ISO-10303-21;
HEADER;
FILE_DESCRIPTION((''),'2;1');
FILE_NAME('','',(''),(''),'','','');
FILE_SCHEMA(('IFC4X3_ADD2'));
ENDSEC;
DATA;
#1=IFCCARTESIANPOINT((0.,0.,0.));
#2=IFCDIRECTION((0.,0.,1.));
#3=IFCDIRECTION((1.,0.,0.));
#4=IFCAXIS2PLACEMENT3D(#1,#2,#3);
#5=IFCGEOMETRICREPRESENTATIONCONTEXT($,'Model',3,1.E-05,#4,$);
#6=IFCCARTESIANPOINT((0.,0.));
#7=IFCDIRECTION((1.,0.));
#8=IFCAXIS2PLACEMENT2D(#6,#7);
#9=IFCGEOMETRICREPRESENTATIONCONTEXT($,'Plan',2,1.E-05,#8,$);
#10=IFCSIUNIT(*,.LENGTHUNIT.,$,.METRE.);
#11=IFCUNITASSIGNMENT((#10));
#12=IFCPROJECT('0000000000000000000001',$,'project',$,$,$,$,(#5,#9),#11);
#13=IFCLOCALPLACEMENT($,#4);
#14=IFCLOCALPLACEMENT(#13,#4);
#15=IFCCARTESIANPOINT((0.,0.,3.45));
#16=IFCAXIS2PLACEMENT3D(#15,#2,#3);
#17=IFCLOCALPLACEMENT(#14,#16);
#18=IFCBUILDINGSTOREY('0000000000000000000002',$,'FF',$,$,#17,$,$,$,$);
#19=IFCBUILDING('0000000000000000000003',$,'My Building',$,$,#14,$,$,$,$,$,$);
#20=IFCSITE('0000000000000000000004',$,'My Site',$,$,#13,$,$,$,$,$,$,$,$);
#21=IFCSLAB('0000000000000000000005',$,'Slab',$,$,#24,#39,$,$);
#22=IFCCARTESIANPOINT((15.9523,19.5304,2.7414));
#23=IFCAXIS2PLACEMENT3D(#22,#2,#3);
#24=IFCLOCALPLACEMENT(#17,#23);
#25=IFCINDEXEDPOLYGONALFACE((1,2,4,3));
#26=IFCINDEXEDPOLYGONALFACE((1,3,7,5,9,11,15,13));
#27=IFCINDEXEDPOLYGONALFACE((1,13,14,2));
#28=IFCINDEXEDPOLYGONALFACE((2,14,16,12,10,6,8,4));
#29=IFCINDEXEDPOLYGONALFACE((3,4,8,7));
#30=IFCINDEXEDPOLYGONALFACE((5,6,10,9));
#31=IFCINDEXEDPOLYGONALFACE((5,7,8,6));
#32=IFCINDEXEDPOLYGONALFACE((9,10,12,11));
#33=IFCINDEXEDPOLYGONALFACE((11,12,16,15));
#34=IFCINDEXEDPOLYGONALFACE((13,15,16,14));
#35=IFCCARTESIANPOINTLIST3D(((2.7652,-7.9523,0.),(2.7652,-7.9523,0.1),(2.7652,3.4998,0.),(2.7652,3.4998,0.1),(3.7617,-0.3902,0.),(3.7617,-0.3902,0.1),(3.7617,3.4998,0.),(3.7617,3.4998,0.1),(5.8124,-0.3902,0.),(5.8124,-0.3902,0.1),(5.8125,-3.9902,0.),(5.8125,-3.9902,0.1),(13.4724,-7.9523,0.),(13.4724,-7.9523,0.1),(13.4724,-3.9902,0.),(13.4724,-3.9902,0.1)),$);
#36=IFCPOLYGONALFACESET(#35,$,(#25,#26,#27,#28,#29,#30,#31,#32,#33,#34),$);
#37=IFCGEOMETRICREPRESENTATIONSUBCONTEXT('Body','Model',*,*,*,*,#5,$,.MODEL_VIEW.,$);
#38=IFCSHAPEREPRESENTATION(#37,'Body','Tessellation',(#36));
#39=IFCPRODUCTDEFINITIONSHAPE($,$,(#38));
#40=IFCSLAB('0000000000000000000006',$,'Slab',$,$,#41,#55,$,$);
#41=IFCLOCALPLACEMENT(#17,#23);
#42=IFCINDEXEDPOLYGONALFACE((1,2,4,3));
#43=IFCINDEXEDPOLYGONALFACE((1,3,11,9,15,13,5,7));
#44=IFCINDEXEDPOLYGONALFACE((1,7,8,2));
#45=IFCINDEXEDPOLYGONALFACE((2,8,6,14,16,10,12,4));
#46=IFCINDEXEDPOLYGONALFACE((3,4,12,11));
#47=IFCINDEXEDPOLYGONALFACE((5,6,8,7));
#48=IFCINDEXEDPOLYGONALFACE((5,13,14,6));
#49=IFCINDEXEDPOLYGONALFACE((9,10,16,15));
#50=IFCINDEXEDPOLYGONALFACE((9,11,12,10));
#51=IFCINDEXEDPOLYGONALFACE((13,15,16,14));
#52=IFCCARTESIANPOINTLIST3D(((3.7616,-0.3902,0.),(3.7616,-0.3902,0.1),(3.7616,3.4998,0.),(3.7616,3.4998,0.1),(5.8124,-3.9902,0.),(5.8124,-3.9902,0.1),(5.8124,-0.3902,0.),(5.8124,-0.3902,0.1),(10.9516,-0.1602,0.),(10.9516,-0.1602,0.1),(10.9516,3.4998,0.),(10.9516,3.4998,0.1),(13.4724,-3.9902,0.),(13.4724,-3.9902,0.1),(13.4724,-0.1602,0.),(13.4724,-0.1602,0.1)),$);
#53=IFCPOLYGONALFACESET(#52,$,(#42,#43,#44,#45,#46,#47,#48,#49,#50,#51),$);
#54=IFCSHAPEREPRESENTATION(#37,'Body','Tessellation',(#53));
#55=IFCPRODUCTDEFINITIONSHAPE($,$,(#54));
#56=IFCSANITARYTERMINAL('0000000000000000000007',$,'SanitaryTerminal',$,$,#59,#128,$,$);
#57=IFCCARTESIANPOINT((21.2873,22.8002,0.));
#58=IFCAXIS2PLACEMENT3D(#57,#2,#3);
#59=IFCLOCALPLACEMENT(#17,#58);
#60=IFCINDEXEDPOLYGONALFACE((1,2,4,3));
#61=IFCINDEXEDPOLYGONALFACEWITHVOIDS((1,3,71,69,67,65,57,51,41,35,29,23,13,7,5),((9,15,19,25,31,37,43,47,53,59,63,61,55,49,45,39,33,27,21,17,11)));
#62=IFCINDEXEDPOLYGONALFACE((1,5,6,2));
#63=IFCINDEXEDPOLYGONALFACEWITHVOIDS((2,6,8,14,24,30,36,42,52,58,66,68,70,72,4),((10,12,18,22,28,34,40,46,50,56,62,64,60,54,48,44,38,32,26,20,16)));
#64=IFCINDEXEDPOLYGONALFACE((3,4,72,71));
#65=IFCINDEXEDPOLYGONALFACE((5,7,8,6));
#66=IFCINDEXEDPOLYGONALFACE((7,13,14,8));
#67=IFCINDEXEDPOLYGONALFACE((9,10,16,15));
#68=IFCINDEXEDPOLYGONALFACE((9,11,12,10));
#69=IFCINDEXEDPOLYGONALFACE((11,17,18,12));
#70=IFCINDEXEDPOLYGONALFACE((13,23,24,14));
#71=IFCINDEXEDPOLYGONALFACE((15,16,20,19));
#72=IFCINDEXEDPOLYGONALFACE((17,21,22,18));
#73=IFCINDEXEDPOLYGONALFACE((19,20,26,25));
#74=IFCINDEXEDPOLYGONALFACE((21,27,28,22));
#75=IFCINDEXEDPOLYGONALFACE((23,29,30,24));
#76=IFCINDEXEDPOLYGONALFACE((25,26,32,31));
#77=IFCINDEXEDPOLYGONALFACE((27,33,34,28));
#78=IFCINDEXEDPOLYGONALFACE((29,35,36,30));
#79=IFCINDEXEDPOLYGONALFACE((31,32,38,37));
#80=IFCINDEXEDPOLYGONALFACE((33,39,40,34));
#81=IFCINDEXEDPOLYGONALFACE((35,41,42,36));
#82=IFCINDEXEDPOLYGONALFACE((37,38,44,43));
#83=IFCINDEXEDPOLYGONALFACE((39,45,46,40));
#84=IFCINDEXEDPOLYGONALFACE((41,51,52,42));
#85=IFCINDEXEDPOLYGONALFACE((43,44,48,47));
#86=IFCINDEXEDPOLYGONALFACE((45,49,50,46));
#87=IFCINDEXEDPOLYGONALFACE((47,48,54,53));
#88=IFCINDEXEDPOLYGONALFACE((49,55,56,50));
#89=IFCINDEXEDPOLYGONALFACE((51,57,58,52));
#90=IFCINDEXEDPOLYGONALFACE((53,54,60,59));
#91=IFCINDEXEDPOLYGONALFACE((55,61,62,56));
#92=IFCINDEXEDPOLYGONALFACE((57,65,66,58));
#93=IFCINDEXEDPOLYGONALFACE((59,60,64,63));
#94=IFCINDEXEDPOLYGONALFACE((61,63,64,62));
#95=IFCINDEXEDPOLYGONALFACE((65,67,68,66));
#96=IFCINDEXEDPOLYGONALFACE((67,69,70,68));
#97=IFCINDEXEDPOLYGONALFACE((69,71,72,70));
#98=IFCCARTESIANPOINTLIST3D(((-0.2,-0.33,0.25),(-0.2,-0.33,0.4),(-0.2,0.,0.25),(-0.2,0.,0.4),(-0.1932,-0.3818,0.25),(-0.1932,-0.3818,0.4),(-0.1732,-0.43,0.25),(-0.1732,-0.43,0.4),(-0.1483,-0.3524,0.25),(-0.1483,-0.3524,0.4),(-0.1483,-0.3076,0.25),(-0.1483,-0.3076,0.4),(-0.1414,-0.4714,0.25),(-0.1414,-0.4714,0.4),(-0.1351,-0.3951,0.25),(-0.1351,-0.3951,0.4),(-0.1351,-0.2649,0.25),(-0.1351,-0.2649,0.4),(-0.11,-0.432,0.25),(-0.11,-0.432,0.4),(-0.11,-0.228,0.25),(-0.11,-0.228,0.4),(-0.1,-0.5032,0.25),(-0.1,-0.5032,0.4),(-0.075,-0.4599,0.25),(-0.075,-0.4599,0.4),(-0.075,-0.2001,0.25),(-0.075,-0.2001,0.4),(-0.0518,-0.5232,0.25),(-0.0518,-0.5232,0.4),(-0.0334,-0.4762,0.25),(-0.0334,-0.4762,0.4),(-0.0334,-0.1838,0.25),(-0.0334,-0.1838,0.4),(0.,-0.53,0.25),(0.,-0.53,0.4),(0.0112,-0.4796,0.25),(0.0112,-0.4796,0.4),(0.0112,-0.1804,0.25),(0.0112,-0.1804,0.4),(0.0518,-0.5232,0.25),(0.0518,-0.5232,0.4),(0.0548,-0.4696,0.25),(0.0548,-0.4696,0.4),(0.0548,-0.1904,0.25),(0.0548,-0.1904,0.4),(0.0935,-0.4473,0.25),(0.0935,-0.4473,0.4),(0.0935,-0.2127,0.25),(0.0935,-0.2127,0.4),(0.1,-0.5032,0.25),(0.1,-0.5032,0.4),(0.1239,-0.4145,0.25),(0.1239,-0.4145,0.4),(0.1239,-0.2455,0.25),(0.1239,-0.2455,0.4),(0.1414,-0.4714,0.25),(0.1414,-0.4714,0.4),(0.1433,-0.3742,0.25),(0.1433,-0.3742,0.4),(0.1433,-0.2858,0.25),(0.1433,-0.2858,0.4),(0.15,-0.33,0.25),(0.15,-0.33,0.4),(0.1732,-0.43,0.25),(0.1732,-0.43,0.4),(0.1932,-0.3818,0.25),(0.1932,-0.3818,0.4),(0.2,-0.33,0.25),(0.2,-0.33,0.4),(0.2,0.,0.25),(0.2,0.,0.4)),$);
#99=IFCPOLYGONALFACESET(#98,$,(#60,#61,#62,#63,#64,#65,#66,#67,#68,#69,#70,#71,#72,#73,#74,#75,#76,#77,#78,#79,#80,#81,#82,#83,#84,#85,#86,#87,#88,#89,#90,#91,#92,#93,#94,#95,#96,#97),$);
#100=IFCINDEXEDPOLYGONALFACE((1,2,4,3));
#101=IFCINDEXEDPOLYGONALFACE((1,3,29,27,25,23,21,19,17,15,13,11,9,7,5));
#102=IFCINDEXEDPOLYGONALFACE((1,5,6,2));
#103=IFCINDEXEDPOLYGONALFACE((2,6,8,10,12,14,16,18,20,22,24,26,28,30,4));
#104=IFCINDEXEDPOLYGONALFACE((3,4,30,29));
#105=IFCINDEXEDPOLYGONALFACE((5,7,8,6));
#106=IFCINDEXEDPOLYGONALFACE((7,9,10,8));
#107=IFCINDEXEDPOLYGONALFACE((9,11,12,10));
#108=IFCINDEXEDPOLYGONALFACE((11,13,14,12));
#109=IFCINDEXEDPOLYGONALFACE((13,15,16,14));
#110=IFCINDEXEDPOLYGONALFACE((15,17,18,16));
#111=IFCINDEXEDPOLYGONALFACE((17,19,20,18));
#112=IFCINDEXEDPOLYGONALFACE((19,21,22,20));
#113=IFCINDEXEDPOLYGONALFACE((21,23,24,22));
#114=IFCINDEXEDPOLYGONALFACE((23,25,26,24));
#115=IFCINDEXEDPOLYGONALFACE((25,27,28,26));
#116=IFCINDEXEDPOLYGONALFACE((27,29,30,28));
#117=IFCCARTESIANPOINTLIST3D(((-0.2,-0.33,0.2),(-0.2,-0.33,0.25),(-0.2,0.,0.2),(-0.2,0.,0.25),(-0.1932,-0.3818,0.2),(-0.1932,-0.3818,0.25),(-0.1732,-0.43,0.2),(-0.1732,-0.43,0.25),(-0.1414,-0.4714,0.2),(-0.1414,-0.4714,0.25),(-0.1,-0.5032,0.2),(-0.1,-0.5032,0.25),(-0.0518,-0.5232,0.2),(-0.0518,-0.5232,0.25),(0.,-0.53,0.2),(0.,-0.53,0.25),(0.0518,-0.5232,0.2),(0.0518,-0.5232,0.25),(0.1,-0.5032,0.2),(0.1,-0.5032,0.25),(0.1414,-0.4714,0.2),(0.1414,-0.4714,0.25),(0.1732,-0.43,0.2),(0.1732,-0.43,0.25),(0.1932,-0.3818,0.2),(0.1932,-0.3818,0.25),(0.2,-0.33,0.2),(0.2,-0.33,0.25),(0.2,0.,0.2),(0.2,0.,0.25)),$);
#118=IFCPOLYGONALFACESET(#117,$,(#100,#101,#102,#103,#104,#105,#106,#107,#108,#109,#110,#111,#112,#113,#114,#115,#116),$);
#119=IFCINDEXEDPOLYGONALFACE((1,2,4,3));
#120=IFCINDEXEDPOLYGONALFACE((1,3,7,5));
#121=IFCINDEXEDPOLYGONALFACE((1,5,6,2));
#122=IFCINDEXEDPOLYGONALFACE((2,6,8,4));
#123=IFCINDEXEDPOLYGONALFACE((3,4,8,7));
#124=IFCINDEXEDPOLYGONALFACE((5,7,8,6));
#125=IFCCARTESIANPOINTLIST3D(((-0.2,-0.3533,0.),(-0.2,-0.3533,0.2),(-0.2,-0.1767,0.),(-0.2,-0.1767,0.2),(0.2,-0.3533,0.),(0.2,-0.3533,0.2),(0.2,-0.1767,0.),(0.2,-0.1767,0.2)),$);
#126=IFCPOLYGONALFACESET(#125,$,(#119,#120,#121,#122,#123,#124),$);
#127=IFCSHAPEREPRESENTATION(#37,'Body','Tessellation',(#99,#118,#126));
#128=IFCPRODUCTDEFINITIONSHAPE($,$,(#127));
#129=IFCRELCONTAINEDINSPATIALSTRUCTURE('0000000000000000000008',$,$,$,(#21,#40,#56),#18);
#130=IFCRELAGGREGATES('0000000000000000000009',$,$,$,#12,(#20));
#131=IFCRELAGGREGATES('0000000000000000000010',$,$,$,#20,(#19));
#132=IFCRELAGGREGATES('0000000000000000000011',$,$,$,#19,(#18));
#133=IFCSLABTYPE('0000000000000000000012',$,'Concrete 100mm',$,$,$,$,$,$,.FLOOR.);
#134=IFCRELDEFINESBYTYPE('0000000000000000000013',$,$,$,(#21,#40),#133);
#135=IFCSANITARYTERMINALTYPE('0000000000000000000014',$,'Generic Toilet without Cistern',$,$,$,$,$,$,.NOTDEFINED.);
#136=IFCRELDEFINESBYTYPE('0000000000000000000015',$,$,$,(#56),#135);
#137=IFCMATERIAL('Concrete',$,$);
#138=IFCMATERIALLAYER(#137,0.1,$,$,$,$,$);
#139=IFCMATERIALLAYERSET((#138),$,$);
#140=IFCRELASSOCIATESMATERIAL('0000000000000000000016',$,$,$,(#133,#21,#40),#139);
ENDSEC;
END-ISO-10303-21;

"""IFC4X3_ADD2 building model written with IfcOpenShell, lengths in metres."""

from ifc_helpers import new_model, entity, si_unit, frame, frame_2d, origin_with_axes, origin_2d_with_axis, place, context, subcontext, project, spatial, line, arc, indexed_curve, circle_curve, outline, extrude, shape, source, transform, mapped, material, layer, layer_set, layer_usage, type_object, type_shapes, element, save


model = new_model("IFC4X3_ADD2")

# Units and contexts
model_context = context("Model", 3, precision=1e-05, world=origin_with_axes())
plan_context = context("Plan", 2, precision=1e-05, world=origin_2d_with_axis())
body_context_1 = subcontext(model_context, "Body", "Model", "MODEL_VIEW")
body_context_2 = subcontext(plan_context, "Body", "Plan", "PLAN_VIEW")
ifc_project = project(units=[si_unit("LENGTHUNIT", "METRE")], contexts=[model_context, plan_context])

# Site, building, storey
site_placement = place(None, origin_with_axes())
site = spatial("IfcSite", under=ifc_project, at=site_placement, Name="My Site")
building_placement = place(site_placement, origin_with_axes())
building = spatial("IfcBuilding", under=site, at=building_placement, Name="My Building")
storey_placement = place(building_placement, frame((0.0, 0.0, 3.45), z_axis=(0.0, 0.0, 1.0), x_axis=(1.0, 0.0, 0.0)))
storey = spatial("IfcBuildingStorey", under=building, at=storey_placement, Name="FF")

# Slabs
ifc_material_1 = material(Name="Concrete")
ifc_layer_1 = layer(ifc_material_1, 0.1)
ifc_layer_set_1 = layer_set([ifc_layer_1])
ifc_layer_usage_1 = layer_usage(ifc_layer_set_1, "AXIS3", "POSITIVE", 0.0)
slab_type = type_object("IfcSlabType", Name="Concrete 100mm", PredefinedType="FLOOR", material=ifc_layer_set_1)
slab_1_placement = place(storey_placement, frame((15.9523, 19.5304, 2.7414), z_axis=(0.0, 0.0, 1.0), x_axis=(1.0, 0.0, 0.0)))
element("IfcSlab", 1, at=slab_1_placement, inside=storey, type_object=slab_type, material=ifc_layer_usage_1, Name="Slab", context=body_context_1, shape_type="SweptSolid", body=[
    extrude(outline(indexed_curve([(13.4724, -7.9523), (13.4724, -3.9902), (5.8125, -3.9902), (5.8124, -0.3902), (3.7617, -0.3902), (3.7617, 3.4998), (2.7652, 3.4998), (2.7652, -7.9523)], segments=[line(5, 6), line(6, 7), line(7, 8), line(8, 1), line(1, 2), line(2, 3), line(3, 4), line(4, 5)], self_intersect=False)), None, (0.0, 0.0, 1.0), 0.1),
])
ifc_layer_usage_2 = layer_usage(ifc_layer_set_1, "AXIS3", "POSITIVE", 0.0)
slab_2_placement = place(storey_placement, frame((15.9523, 19.5304, 2.7414), z_axis=(0.0, 0.0, 1.0), x_axis=(1.0, 0.0, 0.0)))
element("IfcSlab", 2, at=slab_2_placement, inside=storey, type_object=slab_type, material=ifc_layer_usage_2, Name="Slab", context=body_context_1, shape_type="SweptSolid", body=[
    extrude(outline(indexed_curve([(5.8124, -0.3902), (3.7616, -0.3902), (3.7616, 3.4998), (10.9516, 3.4998), (10.9516, -0.1602), (13.4724, -0.1602), (13.4724, -3.9902), (5.8124, -3.9902)], segments=[line(3, 2), line(2, 1), line(1, 8), line(8, 7), line(7, 6), line(6, 5), line(5, 4), line(4, 3)], self_intersect=False)), None, (0.0, 0.0, 1.0), 0.1),
])

# Sanitary terminal
sanitary_terminal_type_1 = type_object("IfcSanitaryTerminalType", Name="Generic Toilet without Cistern", PredefinedType="NOTDEFINED")
shared_shape_1 = source(origin_with_axes(), body_context_1, "Body", "SweptSolid", [
    extrude(outline(indexed_curve([(-0.2, 0.0), (0.2, 0.0), (0.2, -0.33), (0.1414, -0.4714), (0.0, -0.53), (-0.1414, -0.4714), (-0.2, -0.33)], segments=[line(1, 2), line(2, 3), arc(3, 4, 5), arc(5, 6, 7), line(7, 1)]), holes=[circle_curve(frame_2d((0.0, -0.33)), 0.15)]), frame((0.0, 0.0, 0.25), z_axis=(0.0, 0.0, 1.0), x_axis=(1.0, 0.0, 0.0)), (0.0, 0.0, 1.0), 0.15),
    extrude(outline(indexed_curve([(-0.2, 0.0), (0.2, 0.0), (0.2, -0.33), (0.1414, -0.4714), (0.0, -0.53), (-0.1414, -0.4714), (-0.2, -0.33)], segments=[line(1, 2), line(2, 3), arc(3, 4, 5), arc(5, 6, 7), line(7, 1)])), frame((0.0, 0.0, 0.2), z_axis=(0.0, 0.0, 1.0), x_axis=(1.0, 0.0, 0.0)), (0.0, 0.0, 1.0), 0.05),
    extrude(outline(indexed_curve([(-0.2, -0.1767), (0.2, -0.1767), (0.2, -0.3533), (-0.2, -0.3533)], segments=[line(1, 2, 3, 4, 1)])), origin_with_axes(), (0.0, 0.0, 1.0), 0.2),
])
shared_shape_2 = source(origin_with_axes(), body_context_2, "Body", "Annotation2D", [
    entity("IfcGeometricCurveSet", [entity("IfcIndexedPolyCurve", entity("IfcCartesianPointList2D", [[-0.1068, -0.124], [-0.0957, -0.1129], [-0.0804, -0.1088], [0.0804, -0.1088], [0.0957, -0.1129], [0.1068, -0.124], [0.1109, -0.1393], [0.1109, -0.3476], [0.1025, -0.3926], [0.0784, -0.4308], [0.0424, -0.4563], [0.0, -0.4652], [-0.0424, -0.4563], [-0.0784, -0.4308], [-0.1025, -0.3926], [-0.1109, -0.3476], [-0.1109, -0.1393]]), [entity("IfcLineIndex", [1, 2, 3, 4, 5, 6, 7, 8, 9, 10, 11, 12, 13, 14, 15, 16, 17, 1])]), entity("IfcIndexedPolyCurve", entity("IfcCartesianPointList2D", [[-0.1962, -0.2314], [-0.1848, -0.301], [-0.1764, -0.3339], [-0.1663, -0.3651], [-0.1546, -0.3944], [-0.1414, -0.4213], [-0.1269, -0.4458], [-0.1111, -0.4675], [-0.0943, -0.4862], [-0.0765, -0.5018], [-0.0581, -0.514], [-0.039, -0.5229], [-0.0196, -0.5282], [0.0, -0.53], [0.0196, -0.5282], [0.039, -0.5229], [0.0581, -0.514], [0.0765, -0.5018], [0.0943, -0.4862], [0.1111, -0.4675], [0.1269, -0.4458], [0.1414, -0.4213], [0.1546, -0.3944], [0.1663, -0.3651], [0.1764, -0.3339], [0.1848, -0.301], [0.1962, -0.2314], [0.2, -0.159], [0.1872, 0.0], [-0.1872, 0.0], [-0.2, -0.159]]), [entity("IfcLineIndex", [1, 2, 3, 4, 5, 6, 7, 8, 9, 10, 11, 12, 13, 14, 15, 16, 17, 18, 19, 20, 21, 22, 23, 24, 25, 26, 27, 28, 29, 30, 31, 1])])]),
])
type_shapes(sanitary_terminal_type_1, [shared_shape_1, shared_shape_2])
sanitary_terminal_1_placement = place(storey_placement, frame((21.2873, 22.8002, 0.0), z_axis=(0.0, 0.0, 1.0), x_axis=(1.0, 0.0, 0.0)))
element("IfcSanitaryTerminal", 3, at=sanitary_terminal_1_placement, inside=storey, type_object=sanitary_terminal_type_1, Name="SanitaryTerminal", shapes=[
    shape(body_context_1, "Body", "MappedRepresentation", [mapped(shared_shape_1, transform((0.0, 0.0, 0.0), x_axis=(1.0, 0.0, 0.0), y_axis=(0.0, 1.0, 0.0), z_axis=(0.0, 0.0, 1.0), scale=1.0))]),
    shape(body_context_2, "Body", "MappedRepresentation", [mapped(shared_shape_2, transform((0.0, 0.0, 0.0), x_axis=(1.0, 0.0, 0.0), y_axis=(0.0, 1.0, 0.0), z_axis=(0.0, 0.0, 1.0), scale=1.0))]),
])

save(model, "model.ifc")
